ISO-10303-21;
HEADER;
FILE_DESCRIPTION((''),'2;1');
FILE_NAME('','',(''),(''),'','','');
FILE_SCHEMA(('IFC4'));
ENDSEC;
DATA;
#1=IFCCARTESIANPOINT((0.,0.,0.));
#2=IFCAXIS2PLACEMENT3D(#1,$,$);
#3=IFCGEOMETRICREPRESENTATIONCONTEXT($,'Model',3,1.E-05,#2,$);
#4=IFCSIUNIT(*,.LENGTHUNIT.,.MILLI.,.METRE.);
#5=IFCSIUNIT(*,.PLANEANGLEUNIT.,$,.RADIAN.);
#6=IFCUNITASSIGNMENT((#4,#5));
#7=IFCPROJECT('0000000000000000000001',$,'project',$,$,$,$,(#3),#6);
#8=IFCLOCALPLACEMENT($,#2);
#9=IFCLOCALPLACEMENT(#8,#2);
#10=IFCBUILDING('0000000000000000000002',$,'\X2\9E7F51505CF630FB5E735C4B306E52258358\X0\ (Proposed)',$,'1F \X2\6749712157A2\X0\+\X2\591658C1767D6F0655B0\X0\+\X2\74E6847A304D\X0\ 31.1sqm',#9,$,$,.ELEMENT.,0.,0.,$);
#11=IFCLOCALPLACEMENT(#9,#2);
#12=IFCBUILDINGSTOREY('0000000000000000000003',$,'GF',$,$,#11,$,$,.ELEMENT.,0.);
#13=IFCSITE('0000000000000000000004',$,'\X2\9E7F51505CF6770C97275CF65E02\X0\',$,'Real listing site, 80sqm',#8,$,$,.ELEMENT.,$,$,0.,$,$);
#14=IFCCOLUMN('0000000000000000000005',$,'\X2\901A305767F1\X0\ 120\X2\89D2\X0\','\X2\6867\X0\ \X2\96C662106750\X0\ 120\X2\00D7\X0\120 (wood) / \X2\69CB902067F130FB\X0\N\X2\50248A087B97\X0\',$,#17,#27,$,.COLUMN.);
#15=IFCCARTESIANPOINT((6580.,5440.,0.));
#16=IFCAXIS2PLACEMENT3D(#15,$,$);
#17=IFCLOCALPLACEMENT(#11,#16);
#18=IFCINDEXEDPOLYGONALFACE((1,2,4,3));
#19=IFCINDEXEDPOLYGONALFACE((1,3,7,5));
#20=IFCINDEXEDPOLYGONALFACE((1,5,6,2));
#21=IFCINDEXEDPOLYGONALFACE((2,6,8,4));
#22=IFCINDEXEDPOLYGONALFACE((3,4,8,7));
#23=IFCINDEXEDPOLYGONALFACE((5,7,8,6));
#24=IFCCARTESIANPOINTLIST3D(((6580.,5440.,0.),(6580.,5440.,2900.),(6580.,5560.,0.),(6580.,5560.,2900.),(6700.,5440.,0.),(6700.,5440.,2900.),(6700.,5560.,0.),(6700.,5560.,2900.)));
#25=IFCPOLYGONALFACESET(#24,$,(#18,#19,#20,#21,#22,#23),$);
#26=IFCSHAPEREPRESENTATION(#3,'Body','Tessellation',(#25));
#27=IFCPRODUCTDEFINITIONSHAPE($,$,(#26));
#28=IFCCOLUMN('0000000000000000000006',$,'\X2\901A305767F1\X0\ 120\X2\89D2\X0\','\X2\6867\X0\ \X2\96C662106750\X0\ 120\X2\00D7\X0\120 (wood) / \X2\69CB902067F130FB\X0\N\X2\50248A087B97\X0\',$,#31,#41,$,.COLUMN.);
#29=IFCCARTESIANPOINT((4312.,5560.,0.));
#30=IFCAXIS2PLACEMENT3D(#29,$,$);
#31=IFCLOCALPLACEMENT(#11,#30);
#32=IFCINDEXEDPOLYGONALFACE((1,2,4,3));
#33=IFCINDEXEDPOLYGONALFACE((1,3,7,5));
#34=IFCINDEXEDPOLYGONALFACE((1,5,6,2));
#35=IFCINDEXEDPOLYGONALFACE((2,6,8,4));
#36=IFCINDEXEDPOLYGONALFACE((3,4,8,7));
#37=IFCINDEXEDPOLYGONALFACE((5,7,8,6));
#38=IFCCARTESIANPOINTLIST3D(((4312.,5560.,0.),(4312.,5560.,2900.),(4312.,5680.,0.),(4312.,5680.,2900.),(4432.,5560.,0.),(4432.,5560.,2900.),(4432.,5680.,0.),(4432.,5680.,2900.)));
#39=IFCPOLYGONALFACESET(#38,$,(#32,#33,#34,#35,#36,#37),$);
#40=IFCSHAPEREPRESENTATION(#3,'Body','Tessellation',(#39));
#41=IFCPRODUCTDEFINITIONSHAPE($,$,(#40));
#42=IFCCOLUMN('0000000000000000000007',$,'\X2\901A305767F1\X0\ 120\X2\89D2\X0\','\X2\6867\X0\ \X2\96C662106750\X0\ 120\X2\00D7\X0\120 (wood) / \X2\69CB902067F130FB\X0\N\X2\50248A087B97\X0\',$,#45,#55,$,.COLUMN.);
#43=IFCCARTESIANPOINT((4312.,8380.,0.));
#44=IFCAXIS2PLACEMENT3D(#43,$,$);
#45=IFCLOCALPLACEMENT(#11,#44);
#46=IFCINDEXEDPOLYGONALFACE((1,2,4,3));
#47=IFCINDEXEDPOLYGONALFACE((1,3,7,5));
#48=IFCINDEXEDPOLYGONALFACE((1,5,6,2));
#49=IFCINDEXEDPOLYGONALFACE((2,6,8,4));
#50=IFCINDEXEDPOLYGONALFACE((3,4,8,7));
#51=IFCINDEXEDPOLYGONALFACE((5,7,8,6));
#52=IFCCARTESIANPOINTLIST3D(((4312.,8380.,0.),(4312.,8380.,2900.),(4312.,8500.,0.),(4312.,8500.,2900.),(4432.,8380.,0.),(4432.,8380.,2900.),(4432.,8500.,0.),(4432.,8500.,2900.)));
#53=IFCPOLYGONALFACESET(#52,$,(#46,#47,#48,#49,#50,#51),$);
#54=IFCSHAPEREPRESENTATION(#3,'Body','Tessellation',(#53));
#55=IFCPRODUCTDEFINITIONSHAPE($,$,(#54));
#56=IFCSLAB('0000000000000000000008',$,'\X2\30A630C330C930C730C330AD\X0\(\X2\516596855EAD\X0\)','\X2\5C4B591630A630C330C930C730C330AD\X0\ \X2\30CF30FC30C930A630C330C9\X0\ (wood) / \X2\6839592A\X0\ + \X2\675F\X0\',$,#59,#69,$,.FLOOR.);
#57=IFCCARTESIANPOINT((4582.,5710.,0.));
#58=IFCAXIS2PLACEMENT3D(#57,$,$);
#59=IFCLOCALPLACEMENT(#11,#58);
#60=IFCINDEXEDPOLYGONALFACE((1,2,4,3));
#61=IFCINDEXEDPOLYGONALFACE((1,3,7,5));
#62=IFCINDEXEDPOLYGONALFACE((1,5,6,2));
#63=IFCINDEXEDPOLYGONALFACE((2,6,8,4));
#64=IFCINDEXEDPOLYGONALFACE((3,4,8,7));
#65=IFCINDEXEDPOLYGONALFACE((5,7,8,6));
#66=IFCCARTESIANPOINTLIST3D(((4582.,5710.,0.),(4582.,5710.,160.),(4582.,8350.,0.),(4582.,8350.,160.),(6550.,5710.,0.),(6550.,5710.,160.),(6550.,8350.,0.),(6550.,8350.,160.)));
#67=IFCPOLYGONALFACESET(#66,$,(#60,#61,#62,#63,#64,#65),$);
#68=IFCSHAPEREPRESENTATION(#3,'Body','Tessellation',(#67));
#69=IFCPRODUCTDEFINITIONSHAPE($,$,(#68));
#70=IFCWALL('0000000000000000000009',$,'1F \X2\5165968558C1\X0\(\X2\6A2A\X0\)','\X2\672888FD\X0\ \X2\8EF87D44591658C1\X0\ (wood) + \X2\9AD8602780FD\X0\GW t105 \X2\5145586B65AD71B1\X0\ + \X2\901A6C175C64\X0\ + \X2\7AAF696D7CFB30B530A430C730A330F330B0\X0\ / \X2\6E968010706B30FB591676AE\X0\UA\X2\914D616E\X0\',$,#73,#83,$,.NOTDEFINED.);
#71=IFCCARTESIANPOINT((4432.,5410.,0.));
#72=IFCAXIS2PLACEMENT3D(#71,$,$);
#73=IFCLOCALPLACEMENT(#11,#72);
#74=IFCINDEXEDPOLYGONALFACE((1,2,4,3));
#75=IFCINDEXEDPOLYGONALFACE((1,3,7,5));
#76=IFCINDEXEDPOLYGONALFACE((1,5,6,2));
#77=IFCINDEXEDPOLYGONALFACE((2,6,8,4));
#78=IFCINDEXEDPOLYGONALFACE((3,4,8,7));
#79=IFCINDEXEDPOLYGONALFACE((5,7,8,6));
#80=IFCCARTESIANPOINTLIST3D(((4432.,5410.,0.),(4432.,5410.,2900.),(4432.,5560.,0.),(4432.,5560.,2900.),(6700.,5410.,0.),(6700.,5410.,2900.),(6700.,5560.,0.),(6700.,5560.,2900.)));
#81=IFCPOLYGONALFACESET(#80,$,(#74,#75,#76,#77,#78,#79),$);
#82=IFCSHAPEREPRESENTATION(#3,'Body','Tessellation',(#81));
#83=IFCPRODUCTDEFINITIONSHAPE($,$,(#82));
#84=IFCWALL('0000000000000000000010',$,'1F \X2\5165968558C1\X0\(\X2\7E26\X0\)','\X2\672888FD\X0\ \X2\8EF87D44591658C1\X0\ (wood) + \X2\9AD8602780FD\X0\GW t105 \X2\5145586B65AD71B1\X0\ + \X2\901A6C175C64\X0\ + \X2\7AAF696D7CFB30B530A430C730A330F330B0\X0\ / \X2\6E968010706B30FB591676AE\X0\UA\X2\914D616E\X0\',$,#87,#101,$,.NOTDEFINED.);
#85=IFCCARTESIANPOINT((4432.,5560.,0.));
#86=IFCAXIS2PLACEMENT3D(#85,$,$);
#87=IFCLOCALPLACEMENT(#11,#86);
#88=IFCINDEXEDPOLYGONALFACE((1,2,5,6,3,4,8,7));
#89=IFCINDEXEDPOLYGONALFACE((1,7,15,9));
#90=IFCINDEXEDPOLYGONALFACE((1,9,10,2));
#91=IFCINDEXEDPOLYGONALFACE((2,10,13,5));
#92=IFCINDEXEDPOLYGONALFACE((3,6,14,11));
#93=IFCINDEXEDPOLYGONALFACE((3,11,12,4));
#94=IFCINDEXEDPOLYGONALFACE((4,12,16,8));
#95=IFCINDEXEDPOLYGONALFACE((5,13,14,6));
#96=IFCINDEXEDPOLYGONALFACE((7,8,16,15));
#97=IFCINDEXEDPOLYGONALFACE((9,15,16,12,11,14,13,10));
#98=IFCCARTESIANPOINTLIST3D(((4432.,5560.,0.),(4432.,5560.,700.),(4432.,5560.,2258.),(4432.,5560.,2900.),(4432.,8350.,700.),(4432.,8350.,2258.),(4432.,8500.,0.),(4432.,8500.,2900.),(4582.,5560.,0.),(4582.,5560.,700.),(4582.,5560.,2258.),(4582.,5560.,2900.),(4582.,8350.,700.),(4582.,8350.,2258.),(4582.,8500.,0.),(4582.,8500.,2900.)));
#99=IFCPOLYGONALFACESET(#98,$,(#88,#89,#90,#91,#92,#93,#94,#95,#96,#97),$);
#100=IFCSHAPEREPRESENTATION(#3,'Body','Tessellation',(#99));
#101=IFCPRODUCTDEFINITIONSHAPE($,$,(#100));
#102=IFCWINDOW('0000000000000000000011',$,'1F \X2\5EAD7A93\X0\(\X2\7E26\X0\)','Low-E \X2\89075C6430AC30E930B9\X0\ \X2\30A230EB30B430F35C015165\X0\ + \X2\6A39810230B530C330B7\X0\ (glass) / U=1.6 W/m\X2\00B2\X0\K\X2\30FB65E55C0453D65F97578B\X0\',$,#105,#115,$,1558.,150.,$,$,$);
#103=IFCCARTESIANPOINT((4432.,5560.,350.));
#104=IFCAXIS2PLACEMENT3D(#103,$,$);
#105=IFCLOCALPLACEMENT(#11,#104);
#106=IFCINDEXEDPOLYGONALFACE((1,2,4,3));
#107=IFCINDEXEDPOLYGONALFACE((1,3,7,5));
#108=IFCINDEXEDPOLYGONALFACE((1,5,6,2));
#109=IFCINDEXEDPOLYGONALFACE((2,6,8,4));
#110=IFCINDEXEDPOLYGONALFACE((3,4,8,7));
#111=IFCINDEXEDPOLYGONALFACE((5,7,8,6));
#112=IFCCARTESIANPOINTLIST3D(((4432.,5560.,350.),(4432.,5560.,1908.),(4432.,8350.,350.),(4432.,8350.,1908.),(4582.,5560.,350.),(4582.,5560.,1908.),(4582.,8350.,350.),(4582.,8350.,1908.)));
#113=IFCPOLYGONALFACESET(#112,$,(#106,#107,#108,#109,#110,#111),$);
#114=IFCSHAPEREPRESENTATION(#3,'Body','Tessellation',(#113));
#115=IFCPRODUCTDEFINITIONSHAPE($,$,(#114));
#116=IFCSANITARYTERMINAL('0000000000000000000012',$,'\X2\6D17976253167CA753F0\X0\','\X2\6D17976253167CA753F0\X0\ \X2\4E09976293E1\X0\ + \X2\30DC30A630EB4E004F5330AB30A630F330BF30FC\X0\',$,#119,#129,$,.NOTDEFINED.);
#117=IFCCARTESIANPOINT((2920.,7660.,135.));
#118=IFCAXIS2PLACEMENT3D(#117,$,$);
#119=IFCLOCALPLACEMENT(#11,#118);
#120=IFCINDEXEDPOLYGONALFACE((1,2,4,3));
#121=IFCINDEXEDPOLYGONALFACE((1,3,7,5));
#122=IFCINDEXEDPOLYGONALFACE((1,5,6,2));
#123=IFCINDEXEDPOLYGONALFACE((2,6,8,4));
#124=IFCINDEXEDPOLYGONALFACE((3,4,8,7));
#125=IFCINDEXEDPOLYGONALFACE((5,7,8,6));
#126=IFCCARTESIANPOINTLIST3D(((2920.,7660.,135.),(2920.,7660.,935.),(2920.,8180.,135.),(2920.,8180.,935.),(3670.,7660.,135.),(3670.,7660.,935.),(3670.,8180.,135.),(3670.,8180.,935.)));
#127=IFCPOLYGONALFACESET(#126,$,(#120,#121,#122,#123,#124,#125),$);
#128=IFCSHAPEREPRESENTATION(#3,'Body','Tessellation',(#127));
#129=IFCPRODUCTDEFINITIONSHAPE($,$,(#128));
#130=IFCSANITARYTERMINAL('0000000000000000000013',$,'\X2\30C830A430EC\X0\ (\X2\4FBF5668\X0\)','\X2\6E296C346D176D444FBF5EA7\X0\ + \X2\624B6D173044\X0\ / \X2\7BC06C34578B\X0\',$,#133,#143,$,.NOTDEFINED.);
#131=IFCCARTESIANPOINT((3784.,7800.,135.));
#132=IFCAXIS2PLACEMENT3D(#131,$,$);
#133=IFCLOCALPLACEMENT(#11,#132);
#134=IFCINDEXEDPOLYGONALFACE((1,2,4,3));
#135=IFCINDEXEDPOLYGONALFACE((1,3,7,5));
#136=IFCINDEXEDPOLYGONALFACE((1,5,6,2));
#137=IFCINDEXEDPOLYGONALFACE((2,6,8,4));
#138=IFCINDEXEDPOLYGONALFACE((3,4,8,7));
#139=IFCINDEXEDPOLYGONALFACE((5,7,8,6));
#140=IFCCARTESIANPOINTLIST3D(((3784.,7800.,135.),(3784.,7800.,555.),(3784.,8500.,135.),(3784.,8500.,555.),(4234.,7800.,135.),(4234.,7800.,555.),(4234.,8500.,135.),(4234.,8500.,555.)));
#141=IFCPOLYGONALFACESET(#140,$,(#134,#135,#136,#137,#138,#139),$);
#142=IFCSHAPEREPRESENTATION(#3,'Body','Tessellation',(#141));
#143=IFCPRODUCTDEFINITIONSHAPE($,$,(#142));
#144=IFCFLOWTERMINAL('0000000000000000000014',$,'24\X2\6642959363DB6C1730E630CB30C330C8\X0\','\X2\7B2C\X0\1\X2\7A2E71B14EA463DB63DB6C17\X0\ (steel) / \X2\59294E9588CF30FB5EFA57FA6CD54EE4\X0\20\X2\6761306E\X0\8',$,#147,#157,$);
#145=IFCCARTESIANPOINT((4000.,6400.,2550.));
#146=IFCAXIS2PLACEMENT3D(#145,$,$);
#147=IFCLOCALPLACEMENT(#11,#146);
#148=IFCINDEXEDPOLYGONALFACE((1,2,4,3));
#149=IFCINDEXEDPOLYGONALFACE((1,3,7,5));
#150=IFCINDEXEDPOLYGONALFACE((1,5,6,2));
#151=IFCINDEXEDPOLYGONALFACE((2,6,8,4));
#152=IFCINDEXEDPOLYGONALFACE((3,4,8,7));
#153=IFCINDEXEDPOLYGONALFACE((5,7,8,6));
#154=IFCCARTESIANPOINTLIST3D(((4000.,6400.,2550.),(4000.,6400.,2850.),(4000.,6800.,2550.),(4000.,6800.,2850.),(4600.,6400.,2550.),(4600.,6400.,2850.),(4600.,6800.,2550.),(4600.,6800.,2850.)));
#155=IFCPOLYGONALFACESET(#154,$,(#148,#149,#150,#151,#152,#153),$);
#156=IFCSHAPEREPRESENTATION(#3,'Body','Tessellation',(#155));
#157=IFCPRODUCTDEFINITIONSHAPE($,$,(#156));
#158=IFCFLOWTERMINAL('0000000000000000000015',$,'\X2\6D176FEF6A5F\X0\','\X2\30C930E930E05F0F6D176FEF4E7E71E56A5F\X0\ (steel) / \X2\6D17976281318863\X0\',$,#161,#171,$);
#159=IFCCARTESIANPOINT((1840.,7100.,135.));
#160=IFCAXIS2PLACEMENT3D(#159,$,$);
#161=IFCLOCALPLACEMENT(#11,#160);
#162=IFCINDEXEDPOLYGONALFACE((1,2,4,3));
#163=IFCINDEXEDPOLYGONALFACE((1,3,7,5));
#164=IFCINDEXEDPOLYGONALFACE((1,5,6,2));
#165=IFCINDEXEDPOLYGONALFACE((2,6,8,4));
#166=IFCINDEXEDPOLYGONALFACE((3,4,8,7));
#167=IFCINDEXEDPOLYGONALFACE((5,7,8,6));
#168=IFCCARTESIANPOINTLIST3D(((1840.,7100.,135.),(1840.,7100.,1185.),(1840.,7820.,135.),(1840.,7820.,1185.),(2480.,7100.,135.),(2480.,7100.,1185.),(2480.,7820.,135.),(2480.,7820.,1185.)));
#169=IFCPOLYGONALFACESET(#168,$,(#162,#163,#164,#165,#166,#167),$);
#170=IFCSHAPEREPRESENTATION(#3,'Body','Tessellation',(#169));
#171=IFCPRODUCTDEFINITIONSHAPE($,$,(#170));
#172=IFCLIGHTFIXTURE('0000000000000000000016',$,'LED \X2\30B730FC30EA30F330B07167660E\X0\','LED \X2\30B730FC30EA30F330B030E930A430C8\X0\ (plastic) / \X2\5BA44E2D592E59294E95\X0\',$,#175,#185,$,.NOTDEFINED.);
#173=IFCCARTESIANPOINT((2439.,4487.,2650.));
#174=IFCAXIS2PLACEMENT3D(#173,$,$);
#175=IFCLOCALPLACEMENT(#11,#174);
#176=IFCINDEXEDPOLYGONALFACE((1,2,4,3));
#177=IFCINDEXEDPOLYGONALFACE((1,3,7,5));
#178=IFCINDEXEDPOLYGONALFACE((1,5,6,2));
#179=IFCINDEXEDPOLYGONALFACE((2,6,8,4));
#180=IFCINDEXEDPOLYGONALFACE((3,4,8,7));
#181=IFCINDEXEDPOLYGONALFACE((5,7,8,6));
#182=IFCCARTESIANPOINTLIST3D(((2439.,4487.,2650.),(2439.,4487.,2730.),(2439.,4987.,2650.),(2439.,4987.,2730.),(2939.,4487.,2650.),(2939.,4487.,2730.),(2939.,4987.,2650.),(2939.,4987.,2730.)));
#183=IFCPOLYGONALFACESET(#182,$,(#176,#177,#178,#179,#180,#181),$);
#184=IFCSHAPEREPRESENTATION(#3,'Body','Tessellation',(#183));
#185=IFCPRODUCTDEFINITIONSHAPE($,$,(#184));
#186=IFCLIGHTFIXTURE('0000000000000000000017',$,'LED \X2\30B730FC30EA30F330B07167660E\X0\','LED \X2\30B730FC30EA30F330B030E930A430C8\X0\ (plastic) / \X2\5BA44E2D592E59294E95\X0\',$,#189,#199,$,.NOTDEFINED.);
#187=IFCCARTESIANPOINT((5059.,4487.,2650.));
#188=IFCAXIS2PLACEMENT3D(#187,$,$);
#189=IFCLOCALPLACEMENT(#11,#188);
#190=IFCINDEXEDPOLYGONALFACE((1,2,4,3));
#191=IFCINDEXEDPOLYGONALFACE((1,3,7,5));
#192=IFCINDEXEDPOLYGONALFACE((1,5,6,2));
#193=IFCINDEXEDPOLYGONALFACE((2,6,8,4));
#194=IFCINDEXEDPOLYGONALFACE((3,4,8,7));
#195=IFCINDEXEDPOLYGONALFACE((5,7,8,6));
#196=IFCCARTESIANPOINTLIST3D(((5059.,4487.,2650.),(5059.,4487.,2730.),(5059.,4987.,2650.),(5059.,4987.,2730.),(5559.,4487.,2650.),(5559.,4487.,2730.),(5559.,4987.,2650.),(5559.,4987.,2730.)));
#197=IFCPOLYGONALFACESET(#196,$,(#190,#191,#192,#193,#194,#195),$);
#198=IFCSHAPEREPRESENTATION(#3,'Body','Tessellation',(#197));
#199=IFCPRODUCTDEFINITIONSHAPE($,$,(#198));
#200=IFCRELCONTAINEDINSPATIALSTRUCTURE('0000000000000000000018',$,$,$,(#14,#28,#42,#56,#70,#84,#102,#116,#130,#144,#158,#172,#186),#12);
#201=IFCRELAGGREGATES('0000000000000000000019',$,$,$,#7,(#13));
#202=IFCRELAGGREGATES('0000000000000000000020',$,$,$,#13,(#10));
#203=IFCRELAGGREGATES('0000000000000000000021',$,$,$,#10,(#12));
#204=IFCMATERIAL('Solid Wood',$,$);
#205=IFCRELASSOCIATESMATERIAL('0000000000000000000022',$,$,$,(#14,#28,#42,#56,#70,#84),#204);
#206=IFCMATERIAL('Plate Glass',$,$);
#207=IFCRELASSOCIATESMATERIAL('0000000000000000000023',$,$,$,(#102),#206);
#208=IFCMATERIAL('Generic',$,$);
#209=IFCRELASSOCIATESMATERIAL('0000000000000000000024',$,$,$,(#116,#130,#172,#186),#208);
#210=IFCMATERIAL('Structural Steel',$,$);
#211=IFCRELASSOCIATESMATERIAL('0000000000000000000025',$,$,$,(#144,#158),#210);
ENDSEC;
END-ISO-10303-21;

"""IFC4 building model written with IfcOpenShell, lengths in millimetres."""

from ifc_helpers import new_model, si_unit, frame, frame_2d, origin, place, context, project, spatial, rectangle, extrude, material, element, fill, save


model = new_model("IFC4")

# Units and contexts
model_context = context("Model", 3, precision=1e-05, world=origin())
ifc_project = project(units=[si_unit("LENGTHUNIT", "METRE", prefix="MILLI"), si_unit("PLANEANGLEUNIT", "RADIAN")], contexts=[model_context])

# Site, building, storey
site_placement = place(None, origin())
site = spatial("IfcSite", under=ifc_project, at=site_placement, Name="鹿児島県霧島市", ObjectType="Real listing site, 80sqm", CompositionType="ELEMENT", RefElevation=0.0)
building_placement = place(site_placement, origin())
building = spatial("IfcBuilding", under=site, at=building_placement, Name="鹿児島・平屋の別荘 (Proposed)", ObjectType="1F 杉無垢+外壁白漆喰+瓦葺き 31.1sqm", CompositionType="ELEMENT", ElevationOfRefHeight=0.0, ElevationOfTerrain=0.0)
storey_placement = place(building_placement, origin())
storey = spatial("IfcBuildingStorey", under=building, at=storey_placement, Name="GF", CompositionType="ELEMENT", Elevation=0.0)

# Columns
ifc_material_1 = material(Name="Solid Wood")
column_1_placement = place(storey_placement, frame((6580.0, 5440.0, 0.0)))
element("IfcColumn", 1, at=column_1_placement, inside=storey, material=ifc_material_1, Name="通し柱 120角", Description="桧 集成材 120×120 (wood) / 構造柱・N値計算", PredefinedType="COLUMN", context=model_context, shape_type="SweptSolid", body=[
    extrude(rectangle(XDim=120.0, YDim=120.0, at=frame_2d((60.0, 60.0))), frame((6580.0, 5440.0, 0.0)), (0.0, 0.0, 1.0), 2900.0),
])
column_2_placement = place(storey_placement, frame((4312.0, 5560.0, 0.0)))
element("IfcColumn", 2, at=column_2_placement, inside=storey, material=ifc_material_1, Name="通し柱 120角", Description="桧 集成材 120×120 (wood) / 構造柱・N値計算", PredefinedType="COLUMN", context=model_context, shape_type="SweptSolid", body=[
    extrude(rectangle(XDim=120.0, YDim=120.0, at=frame_2d((60.0, 60.0))), frame((4312.0, 5560.0, 0.0)), (0.0, 0.0, 1.0), 2900.0),
])
column_3_placement = place(storey_placement, frame((4312.0, 8380.0, 0.0)))
element("IfcColumn", 3, at=column_3_placement, inside=storey, material=ifc_material_1, Name="通し柱 120角", Description="桧 集成材 120×120 (wood) / 構造柱・N値計算", PredefinedType="COLUMN", context=model_context, shape_type="SweptSolid", body=[
    extrude(rectangle(XDim=120.0, YDim=120.0, at=frame_2d((60.0, 60.0))), frame((4312.0, 8380.0, 0.0)), (0.0, 0.0, 1.0), 2900.0),
])

# Slab
slab_placement = place(storey_placement, frame((4582.0, 5710.0, 0.0)))
element("IfcSlab", 4, at=slab_placement, inside=storey, material=ifc_material_1, Name="ウッドデッキ(入隅庭)", Description="屋外ウッドデッキ ハードウッド (wood) / 根太 + 束", PredefinedType="FLOOR", context=model_context, shape_type="SweptSolid", body=[
    extrude(rectangle(XDim=1968.0, YDim=2640.0, at=frame_2d((984.0, 1320.0))), frame((4582.0, 5710.0, 0.0)), (0.0, 0.0, 1.0), 160.0),
])

# Wall
wall_1_placement = place(storey_placement, frame((4432.0, 5410.0, 0.0)))
element("IfcWall", 5, at=wall_1_placement, inside=storey, material=ifc_material_1, Name="1F 入隅壁(横)", Description="木製 軸組外壁 (wood) + 高性能GW t105 充填断熱 + 通気層 + 窯業系サイディング / 準耐火・外皮UA配慮", PredefinedType="NOTDEFINED", context=model_context, shape_type="SweptSolid", body=[
    extrude(rectangle(XDim=2268.0, YDim=150.0, at=frame_2d((1134.0, 75.0))), frame((4432.0, 5410.0, 0.0)), (0.0, 0.0, 1.0), 2900.0),
])

# Wall, opening, window
wall_2_placement = place(storey_placement, frame((4432.0, 5560.0, 0.0)))
wall_2 = element("IfcWall", 6, at=wall_2_placement, inside=storey, material=ifc_material_1, Name="1F 入隅壁(縦)", Description="木製 軸組外壁 (wood) + 高性能GW t105 充填断熱 + 通気層 + 窯業系サイディング / 準耐火・外皮UA配慮", PredefinedType="NOTDEFINED", context=model_context, shape_type="SweptSolid", body=[
    extrude(rectangle(XDim=150.0, YDim=2940.0, at=frame_2d((75.0, 1470.0))), frame((4432.0, 5560.0, 0.0)), (0.0, 0.0, 1.0), 2900.0),
])
opening_placement = place(storey_placement, frame((4432.0, 5560.0, 350.0)))
opening = element("IfcOpeningElement", 7, at=opening_placement, cuts=wall_2, PredefinedType="NOTDEFINED", context=model_context, shape_type="SweptSolid", body=[
    extrude(rectangle(XDim=150.0, YDim=2790.0, at=frame_2d((75.0, 1395.0))), frame((4432.0, 5560.0, 350.0)), (0.0, 0.0, 1.0), 1558.0),
])
ifc_material_2 = material(Name="Plate Glass")
window_placement = place(storey_placement, frame((4432.0, 5560.0, 350.0)))
window = element("IfcWindow", 8, at=window_placement, inside=storey, material=ifc_material_2, Name="1F 庭窓(縦)", Description="Low-E 複層ガラス アルゴン封入 + 樹脂サッシ (glass) / U=1.6 W/m²K・日射取得型", OverallHeight=1558.0, OverallWidth=150.0, context=model_context, shape_type="SweptSolid", body=[
    extrude(rectangle(XDim=150.0, YDim=2790.0, at=frame_2d((75.0, 1395.0))), frame((4432.0, 5560.0, 350.0)), (0.0, 0.0, 1.0), 1558.0),
])
fill(opening, window)

# Sanitary terminals
ifc_material_3 = material(Name="Generic")
sanitary_terminal_1_placement = place(storey_placement, frame((2920.0, 7660.0, 135.0)))
element("IfcSanitaryTerminal", 9, at=sanitary_terminal_1_placement, inside=storey, material=ifc_material_3, Name="洗面化粧台", Description="洗面化粧台 三面鏡 + ボウル一体カウンター", PredefinedType="NOTDEFINED", context=model_context, shape_type="SweptSolid", body=[
    extrude(rectangle(XDim=750.0, YDim=520.0, at=frame_2d((375.0, 260.0))), frame((2920.0, 7660.0, 135.0)), (0.0, 0.0, 1.0), 800.0),
])
sanitary_terminal_2_placement = place(storey_placement, frame((3784.0, 7800.0, 135.0)))
element("IfcSanitaryTerminal", 10, at=sanitary_terminal_2_placement, inside=storey, material=ifc_material_3, Name="トイレ (便器)", Description="温水洗浄便座 + 手洗い / 節水型", PredefinedType="NOTDEFINED", context=model_context, shape_type="SweptSolid", body=[
    extrude(rectangle(XDim=450.0, YDim=700.0, at=frame_2d((225.0, 350.0))), frame((3784.0, 7800.0, 135.0)), (0.0, 0.0, 1.0), 420.0),
])

# Flow terminals
ifc_material_4 = material(Name="Structural Steel")
flow_terminal_1_placement = place(storey_placement, frame((4000.0, 6400.0, 2550.0)))
element("IfcFlowTerminal", 11, at=flow_terminal_1_placement, inside=storey, material=ifc_material_4, Name="24時間換気ユニット", Description="第1種熱交換換気 (steel) / 天井裏・建基法令20条の8", context=model_context, shape_type="SweptSolid", body=[
    extrude(rectangle(XDim=600.0, YDim=400.0, at=frame_2d((300.0, 200.0))), frame((4000.0, 6400.0, 2550.0)), (0.0, 0.0, 1.0), 300.0),
])
flow_terminal_2_placement = place(storey_placement, frame((1840.0, 7100.0, 135.0)))
element("IfcFlowTerminal", 12, at=flow_terminal_2_placement, inside=storey, material=ifc_material_4, Name="洗濯機", Description="ドラム式洗濯乾燥機 (steel) / 洗面脱衣", context=model_context, shape_type="SweptSolid", body=[
    extrude(rectangle(XDim=640.0, YDim=720.0, at=frame_2d((320.0, 360.0))), frame((1840.0, 7100.0, 135.0)), (0.0, 0.0, 1.0), 1050.0),
])

# Light fixtures
light_fixture_1_placement = place(storey_placement, frame((2439.0, 4487.0, 2650.0)))
element("IfcLightFixture", 13, at=light_fixture_1_placement, inside=storey, material=ifc_material_3, Name="LED シーリング照明", Description="LED シーリングライト (plastic) / 室中央天井", PredefinedType="NOTDEFINED", context=model_context, shape_type="SweptSolid", body=[
    extrude(rectangle(XDim=500.0, YDim=500.0, at=frame_2d((250.0, 250.0))), frame((2439.0, 4487.0, 2650.0)), (0.0, 0.0, 1.0), 80.0),
])
light_fixture_2_placement = place(storey_placement, frame((5059.0, 4487.0, 2650.0)))
element("IfcLightFixture", 14, at=light_fixture_2_placement, inside=storey, material=ifc_material_3, Name="LED シーリング照明", Description="LED シーリングライト (plastic) / 室中央天井", PredefinedType="NOTDEFINED", context=model_context, shape_type="SweptSolid", body=[
    extrude(rectangle(XDim=500.0, YDim=500.0, at=frame_2d((250.0, 250.0))), frame((5059.0, 4487.0, 2650.0)), (0.0, 0.0, 1.0), 80.0),
])

save(model, "model.ifc")
